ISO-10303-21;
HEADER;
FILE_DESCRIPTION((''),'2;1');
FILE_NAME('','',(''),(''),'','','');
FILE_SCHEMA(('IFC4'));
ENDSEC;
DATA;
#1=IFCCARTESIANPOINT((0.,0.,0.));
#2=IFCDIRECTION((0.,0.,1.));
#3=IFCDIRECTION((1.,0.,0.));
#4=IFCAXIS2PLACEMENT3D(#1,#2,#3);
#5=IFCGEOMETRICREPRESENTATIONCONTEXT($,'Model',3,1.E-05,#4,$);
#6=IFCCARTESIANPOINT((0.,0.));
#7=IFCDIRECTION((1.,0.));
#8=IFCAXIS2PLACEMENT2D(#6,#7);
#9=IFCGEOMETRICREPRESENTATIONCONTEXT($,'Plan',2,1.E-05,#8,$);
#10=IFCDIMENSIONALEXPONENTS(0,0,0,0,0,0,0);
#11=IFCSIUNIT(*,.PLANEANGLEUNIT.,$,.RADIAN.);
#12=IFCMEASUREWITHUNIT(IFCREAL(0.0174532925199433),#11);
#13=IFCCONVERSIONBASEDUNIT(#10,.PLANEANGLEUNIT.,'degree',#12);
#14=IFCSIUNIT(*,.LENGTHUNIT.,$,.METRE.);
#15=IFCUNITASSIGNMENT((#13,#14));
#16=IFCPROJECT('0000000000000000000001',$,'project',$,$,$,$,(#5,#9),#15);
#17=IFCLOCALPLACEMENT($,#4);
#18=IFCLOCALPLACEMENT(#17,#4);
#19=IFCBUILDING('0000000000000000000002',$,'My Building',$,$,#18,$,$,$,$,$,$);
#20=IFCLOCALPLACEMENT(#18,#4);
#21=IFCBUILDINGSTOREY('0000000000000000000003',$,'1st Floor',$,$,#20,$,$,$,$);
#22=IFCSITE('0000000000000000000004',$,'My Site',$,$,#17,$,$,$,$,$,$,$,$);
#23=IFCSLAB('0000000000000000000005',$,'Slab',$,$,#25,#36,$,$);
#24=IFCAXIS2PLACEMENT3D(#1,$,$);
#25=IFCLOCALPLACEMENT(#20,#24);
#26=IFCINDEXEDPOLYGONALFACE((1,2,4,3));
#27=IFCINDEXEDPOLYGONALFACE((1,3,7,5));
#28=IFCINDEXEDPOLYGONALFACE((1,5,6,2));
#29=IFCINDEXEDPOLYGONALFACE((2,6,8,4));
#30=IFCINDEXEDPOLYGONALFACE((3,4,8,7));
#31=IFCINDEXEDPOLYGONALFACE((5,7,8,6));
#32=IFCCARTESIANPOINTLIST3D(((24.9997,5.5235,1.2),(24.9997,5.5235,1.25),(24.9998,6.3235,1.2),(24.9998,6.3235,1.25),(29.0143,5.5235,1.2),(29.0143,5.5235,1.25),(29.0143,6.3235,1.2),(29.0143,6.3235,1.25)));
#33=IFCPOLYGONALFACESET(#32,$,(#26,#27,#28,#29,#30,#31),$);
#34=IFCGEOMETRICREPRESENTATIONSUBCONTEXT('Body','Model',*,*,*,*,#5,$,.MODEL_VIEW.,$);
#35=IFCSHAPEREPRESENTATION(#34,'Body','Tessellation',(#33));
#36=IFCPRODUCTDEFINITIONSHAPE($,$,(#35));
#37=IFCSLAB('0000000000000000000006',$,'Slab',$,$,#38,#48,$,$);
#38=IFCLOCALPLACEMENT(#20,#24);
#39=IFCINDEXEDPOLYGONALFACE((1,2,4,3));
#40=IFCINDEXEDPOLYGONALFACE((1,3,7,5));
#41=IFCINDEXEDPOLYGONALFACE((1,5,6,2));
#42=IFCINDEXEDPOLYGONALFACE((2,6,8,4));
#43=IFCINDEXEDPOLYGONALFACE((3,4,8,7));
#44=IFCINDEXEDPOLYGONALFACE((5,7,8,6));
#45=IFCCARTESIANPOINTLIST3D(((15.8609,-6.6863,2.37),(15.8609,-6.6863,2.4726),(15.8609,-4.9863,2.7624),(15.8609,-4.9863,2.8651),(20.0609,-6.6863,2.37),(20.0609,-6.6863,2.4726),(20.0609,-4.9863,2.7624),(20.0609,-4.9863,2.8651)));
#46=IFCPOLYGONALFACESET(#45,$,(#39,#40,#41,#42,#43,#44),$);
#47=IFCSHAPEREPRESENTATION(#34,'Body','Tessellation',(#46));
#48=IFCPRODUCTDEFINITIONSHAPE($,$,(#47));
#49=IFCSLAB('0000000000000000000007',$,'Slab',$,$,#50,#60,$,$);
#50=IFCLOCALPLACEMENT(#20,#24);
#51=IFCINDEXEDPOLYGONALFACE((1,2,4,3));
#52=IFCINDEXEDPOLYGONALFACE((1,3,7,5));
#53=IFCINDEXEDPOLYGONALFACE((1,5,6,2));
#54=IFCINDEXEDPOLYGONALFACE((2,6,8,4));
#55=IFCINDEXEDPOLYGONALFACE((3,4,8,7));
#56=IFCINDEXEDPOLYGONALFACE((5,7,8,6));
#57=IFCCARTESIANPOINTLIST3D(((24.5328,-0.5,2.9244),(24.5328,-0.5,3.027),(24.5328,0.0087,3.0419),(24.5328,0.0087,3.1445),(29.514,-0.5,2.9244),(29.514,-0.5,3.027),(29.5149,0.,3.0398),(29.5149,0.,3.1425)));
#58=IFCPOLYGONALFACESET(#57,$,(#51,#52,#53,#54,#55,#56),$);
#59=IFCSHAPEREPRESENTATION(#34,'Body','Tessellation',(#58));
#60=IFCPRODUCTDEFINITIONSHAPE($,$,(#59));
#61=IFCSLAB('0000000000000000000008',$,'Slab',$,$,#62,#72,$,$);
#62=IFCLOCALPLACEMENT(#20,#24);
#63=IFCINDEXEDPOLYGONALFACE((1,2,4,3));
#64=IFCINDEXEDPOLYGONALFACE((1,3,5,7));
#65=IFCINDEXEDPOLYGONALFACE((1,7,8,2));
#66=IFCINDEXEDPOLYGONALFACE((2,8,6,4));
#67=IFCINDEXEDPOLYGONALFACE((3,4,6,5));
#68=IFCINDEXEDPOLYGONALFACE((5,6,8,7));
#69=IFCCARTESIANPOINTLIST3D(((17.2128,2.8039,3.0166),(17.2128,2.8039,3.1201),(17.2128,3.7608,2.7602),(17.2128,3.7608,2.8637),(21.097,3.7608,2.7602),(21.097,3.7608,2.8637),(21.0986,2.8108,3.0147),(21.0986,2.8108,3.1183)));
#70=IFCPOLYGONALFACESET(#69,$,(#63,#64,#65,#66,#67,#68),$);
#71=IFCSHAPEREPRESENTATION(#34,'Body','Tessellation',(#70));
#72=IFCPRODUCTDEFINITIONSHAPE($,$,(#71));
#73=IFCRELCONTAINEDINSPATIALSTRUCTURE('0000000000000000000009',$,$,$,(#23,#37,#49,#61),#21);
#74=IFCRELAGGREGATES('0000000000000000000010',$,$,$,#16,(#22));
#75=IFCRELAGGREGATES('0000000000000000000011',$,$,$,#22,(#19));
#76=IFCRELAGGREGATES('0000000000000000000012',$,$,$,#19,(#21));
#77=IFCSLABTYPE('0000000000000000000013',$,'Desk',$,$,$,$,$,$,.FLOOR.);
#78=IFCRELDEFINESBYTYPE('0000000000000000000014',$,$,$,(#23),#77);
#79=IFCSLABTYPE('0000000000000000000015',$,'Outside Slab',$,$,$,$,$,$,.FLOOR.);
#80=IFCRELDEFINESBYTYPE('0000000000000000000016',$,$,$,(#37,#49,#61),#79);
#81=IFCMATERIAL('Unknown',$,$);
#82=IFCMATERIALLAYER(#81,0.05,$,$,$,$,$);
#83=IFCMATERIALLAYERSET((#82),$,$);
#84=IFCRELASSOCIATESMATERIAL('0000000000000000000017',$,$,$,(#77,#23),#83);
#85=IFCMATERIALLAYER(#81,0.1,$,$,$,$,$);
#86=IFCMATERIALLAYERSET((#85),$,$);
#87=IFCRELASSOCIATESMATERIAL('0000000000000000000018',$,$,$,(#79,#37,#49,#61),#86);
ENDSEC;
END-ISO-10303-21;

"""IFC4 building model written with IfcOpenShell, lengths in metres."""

from ifc_helpers import new_model, entity, si_unit, converted_unit, frame, origin_with_axes, origin_2d_with_axis, place, context, subcontext, project, spatial, indexed_curve, outline, extrude, material, layer, layer_set, layer_usage, type_object, element, save


model = new_model("IFC4")

# Units and contexts
model_context = context("Model", 3, precision=1e-05, world=origin_with_axes())
plan_context = context("Plan", 2, precision=1e-05, world=origin_2d_with_axis())
body_context_1 = subcontext(model_context, "Body", "Model", "MODEL_VIEW")
ifc_project = project(units=[converted_unit("PLANEANGLEUNIT", "degree", entity("IfcReal", 0.0174532925199433), si_unit("PLANEANGLEUNIT", "RADIAN"), dimensions=[0, 0, 0, 0, 0, 0, 0]), si_unit("LENGTHUNIT", "METRE")], contexts=[model_context, plan_context])

# Site, building, storey
site_placement = place(None, origin_with_axes())
site = spatial("IfcSite", under=ifc_project, at=site_placement, Name="My Site")
building_placement = place(site_placement, origin_with_axes())
building = spatial("IfcBuilding", under=site, at=building_placement, Name="My Building")
storey_placement = place(building_placement, origin_with_axes())
storey = spatial("IfcBuildingStorey", under=building, at=storey_placement, Name="1st Floor")

# Shared definitions
ifc_material = material(Name="Unknown")

# Slabs
ifc_layer_1 = layer(ifc_material, 0.05)
ifc_layer_set_1 = layer_set([ifc_layer_1])
ifc_layer_usage_1 = layer_usage(ifc_layer_set_1, "AXIS3", "POSITIVE", -0.05)
slab_type_1 = type_object("IfcSlabType", Name="Desk", PredefinedType="FLOOR", material=ifc_layer_set_1)
slab_1_placement = place(storey_placement, frame((24.9997, 5.5235, 1.25), z_axis=(0.0, 0.0, 1.0), x_axis=(1.0, 0.0, 0.0)))
element("IfcSlab", 1, at=slab_1_placement, inside=storey, type_object=slab_type_1, material=ifc_layer_usage_1, Name="Slab", context=body_context_1, shape_type="SweptSolid", body=[
    extrude(outline(indexed_curve([(0.0, 0.0), (4.0146, 0.0), (4.0146, 0.8), (0.0, 0.8), (0.0, 0.0)])), frame((0.0, 0.0, -0.05), z_axis=(0.0, 0.0, 1.0), x_axis=(1.0, 0.0, 0.0)), (0.0, 0.0, 1.0), 0.05),
])
ifc_layer_2 = layer(ifc_material, 0.1)
ifc_layer_set_2 = layer_set([ifc_layer_2])
ifc_layer_usage_2 = layer_usage(ifc_layer_set_2, "AXIS3", "POSITIVE", -0.1)
slab_type_2 = type_object("IfcSlabType", Name="Outside Slab", PredefinedType="FLOOR", material=ifc_layer_set_2)
slab_2_placement = place(storey_placement, frame((15.8609, -4.9863, 2.8651), z_axis=(0.0, -0.224951, 0.97437), x_axis=(1.0, 0.0, 0.0)))
element("IfcSlab", 2, at=slab_2_placement, inside=storey, type_object=slab_type_2, material=ifc_layer_usage_2, Name="Slab", context=body_context_1, shape_type="SweptSolid", body=[
    extrude(outline(indexed_curve([(0.0, 0.0), (0.0, -1.7447), (4.2, -1.7447), (4.2, 0.0), (0.0, 0.0)])), frame((0.0, -0.0231, -0.1), z_axis=(0.0, 0.0, 1.0), x_axis=(1.0, 0.0, 0.0)), (0.0, 0.224951, 0.97437), 0.1026),
])
ifc_layer_usage_3 = layer_usage(ifc_layer_set_2, "AXIS3", "POSITIVE", -0.1)
slab_3_placement = place(storey_placement, frame((24.5328, 0.0087, 3.1445), z_axis=(0.0, -0.224951, 0.97437), x_axis=(1.0, 0.0, 0.0)))
element("IfcSlab", 3, at=slab_3_placement, inside=storey, type_object=slab_type_2, material=ifc_layer_usage_3, Name="Slab", context=body_context_1, shape_type="SweptSolid", body=[
    extrude(outline(indexed_curve([(0.0, 0.0), (4.9821, -0.009), (4.9812, -0.5221), (0.0, -0.5221), (0.0, 0.0)])), frame((0.0, -0.0231, -0.1), z_axis=(0.0, 0.0, 1.0), x_axis=(1.0, 0.0, 0.0)), (0.0, 0.224951, 0.97437), 0.1026),
])
ifc_layer_usage_4 = layer_usage(ifc_layer_set_2, "AXIS3", "POSITIVE", -0.1)
slab_4_placement = place(storey_placement, frame((17.2128, 2.8039, 3.1201), z_axis=(0.0, 0.258819, 0.965926), x_axis=(1.0, 0.0, 0.0)))
element("IfcSlab", 4, at=slab_4_placement, inside=storey, type_object=slab_type_2, material=ifc_layer_usage_4, Name="Slab", context=body_context_1, shape_type="SweptSolid", body=[
    extrude(outline(indexed_curve([(0.0, 0.0), (3.8858, 0.0071), (3.8841, 0.9906), (0.0, 0.9906), (0.0, 0.0)])), frame((0.0, 0.0268, -0.1), z_axis=(0.0, 0.0, 1.0), x_axis=(1.0, 0.0, 0.0)), (0.0, -0.258819, 0.965926), 0.1035),
])

save(model, "model.ifc")
